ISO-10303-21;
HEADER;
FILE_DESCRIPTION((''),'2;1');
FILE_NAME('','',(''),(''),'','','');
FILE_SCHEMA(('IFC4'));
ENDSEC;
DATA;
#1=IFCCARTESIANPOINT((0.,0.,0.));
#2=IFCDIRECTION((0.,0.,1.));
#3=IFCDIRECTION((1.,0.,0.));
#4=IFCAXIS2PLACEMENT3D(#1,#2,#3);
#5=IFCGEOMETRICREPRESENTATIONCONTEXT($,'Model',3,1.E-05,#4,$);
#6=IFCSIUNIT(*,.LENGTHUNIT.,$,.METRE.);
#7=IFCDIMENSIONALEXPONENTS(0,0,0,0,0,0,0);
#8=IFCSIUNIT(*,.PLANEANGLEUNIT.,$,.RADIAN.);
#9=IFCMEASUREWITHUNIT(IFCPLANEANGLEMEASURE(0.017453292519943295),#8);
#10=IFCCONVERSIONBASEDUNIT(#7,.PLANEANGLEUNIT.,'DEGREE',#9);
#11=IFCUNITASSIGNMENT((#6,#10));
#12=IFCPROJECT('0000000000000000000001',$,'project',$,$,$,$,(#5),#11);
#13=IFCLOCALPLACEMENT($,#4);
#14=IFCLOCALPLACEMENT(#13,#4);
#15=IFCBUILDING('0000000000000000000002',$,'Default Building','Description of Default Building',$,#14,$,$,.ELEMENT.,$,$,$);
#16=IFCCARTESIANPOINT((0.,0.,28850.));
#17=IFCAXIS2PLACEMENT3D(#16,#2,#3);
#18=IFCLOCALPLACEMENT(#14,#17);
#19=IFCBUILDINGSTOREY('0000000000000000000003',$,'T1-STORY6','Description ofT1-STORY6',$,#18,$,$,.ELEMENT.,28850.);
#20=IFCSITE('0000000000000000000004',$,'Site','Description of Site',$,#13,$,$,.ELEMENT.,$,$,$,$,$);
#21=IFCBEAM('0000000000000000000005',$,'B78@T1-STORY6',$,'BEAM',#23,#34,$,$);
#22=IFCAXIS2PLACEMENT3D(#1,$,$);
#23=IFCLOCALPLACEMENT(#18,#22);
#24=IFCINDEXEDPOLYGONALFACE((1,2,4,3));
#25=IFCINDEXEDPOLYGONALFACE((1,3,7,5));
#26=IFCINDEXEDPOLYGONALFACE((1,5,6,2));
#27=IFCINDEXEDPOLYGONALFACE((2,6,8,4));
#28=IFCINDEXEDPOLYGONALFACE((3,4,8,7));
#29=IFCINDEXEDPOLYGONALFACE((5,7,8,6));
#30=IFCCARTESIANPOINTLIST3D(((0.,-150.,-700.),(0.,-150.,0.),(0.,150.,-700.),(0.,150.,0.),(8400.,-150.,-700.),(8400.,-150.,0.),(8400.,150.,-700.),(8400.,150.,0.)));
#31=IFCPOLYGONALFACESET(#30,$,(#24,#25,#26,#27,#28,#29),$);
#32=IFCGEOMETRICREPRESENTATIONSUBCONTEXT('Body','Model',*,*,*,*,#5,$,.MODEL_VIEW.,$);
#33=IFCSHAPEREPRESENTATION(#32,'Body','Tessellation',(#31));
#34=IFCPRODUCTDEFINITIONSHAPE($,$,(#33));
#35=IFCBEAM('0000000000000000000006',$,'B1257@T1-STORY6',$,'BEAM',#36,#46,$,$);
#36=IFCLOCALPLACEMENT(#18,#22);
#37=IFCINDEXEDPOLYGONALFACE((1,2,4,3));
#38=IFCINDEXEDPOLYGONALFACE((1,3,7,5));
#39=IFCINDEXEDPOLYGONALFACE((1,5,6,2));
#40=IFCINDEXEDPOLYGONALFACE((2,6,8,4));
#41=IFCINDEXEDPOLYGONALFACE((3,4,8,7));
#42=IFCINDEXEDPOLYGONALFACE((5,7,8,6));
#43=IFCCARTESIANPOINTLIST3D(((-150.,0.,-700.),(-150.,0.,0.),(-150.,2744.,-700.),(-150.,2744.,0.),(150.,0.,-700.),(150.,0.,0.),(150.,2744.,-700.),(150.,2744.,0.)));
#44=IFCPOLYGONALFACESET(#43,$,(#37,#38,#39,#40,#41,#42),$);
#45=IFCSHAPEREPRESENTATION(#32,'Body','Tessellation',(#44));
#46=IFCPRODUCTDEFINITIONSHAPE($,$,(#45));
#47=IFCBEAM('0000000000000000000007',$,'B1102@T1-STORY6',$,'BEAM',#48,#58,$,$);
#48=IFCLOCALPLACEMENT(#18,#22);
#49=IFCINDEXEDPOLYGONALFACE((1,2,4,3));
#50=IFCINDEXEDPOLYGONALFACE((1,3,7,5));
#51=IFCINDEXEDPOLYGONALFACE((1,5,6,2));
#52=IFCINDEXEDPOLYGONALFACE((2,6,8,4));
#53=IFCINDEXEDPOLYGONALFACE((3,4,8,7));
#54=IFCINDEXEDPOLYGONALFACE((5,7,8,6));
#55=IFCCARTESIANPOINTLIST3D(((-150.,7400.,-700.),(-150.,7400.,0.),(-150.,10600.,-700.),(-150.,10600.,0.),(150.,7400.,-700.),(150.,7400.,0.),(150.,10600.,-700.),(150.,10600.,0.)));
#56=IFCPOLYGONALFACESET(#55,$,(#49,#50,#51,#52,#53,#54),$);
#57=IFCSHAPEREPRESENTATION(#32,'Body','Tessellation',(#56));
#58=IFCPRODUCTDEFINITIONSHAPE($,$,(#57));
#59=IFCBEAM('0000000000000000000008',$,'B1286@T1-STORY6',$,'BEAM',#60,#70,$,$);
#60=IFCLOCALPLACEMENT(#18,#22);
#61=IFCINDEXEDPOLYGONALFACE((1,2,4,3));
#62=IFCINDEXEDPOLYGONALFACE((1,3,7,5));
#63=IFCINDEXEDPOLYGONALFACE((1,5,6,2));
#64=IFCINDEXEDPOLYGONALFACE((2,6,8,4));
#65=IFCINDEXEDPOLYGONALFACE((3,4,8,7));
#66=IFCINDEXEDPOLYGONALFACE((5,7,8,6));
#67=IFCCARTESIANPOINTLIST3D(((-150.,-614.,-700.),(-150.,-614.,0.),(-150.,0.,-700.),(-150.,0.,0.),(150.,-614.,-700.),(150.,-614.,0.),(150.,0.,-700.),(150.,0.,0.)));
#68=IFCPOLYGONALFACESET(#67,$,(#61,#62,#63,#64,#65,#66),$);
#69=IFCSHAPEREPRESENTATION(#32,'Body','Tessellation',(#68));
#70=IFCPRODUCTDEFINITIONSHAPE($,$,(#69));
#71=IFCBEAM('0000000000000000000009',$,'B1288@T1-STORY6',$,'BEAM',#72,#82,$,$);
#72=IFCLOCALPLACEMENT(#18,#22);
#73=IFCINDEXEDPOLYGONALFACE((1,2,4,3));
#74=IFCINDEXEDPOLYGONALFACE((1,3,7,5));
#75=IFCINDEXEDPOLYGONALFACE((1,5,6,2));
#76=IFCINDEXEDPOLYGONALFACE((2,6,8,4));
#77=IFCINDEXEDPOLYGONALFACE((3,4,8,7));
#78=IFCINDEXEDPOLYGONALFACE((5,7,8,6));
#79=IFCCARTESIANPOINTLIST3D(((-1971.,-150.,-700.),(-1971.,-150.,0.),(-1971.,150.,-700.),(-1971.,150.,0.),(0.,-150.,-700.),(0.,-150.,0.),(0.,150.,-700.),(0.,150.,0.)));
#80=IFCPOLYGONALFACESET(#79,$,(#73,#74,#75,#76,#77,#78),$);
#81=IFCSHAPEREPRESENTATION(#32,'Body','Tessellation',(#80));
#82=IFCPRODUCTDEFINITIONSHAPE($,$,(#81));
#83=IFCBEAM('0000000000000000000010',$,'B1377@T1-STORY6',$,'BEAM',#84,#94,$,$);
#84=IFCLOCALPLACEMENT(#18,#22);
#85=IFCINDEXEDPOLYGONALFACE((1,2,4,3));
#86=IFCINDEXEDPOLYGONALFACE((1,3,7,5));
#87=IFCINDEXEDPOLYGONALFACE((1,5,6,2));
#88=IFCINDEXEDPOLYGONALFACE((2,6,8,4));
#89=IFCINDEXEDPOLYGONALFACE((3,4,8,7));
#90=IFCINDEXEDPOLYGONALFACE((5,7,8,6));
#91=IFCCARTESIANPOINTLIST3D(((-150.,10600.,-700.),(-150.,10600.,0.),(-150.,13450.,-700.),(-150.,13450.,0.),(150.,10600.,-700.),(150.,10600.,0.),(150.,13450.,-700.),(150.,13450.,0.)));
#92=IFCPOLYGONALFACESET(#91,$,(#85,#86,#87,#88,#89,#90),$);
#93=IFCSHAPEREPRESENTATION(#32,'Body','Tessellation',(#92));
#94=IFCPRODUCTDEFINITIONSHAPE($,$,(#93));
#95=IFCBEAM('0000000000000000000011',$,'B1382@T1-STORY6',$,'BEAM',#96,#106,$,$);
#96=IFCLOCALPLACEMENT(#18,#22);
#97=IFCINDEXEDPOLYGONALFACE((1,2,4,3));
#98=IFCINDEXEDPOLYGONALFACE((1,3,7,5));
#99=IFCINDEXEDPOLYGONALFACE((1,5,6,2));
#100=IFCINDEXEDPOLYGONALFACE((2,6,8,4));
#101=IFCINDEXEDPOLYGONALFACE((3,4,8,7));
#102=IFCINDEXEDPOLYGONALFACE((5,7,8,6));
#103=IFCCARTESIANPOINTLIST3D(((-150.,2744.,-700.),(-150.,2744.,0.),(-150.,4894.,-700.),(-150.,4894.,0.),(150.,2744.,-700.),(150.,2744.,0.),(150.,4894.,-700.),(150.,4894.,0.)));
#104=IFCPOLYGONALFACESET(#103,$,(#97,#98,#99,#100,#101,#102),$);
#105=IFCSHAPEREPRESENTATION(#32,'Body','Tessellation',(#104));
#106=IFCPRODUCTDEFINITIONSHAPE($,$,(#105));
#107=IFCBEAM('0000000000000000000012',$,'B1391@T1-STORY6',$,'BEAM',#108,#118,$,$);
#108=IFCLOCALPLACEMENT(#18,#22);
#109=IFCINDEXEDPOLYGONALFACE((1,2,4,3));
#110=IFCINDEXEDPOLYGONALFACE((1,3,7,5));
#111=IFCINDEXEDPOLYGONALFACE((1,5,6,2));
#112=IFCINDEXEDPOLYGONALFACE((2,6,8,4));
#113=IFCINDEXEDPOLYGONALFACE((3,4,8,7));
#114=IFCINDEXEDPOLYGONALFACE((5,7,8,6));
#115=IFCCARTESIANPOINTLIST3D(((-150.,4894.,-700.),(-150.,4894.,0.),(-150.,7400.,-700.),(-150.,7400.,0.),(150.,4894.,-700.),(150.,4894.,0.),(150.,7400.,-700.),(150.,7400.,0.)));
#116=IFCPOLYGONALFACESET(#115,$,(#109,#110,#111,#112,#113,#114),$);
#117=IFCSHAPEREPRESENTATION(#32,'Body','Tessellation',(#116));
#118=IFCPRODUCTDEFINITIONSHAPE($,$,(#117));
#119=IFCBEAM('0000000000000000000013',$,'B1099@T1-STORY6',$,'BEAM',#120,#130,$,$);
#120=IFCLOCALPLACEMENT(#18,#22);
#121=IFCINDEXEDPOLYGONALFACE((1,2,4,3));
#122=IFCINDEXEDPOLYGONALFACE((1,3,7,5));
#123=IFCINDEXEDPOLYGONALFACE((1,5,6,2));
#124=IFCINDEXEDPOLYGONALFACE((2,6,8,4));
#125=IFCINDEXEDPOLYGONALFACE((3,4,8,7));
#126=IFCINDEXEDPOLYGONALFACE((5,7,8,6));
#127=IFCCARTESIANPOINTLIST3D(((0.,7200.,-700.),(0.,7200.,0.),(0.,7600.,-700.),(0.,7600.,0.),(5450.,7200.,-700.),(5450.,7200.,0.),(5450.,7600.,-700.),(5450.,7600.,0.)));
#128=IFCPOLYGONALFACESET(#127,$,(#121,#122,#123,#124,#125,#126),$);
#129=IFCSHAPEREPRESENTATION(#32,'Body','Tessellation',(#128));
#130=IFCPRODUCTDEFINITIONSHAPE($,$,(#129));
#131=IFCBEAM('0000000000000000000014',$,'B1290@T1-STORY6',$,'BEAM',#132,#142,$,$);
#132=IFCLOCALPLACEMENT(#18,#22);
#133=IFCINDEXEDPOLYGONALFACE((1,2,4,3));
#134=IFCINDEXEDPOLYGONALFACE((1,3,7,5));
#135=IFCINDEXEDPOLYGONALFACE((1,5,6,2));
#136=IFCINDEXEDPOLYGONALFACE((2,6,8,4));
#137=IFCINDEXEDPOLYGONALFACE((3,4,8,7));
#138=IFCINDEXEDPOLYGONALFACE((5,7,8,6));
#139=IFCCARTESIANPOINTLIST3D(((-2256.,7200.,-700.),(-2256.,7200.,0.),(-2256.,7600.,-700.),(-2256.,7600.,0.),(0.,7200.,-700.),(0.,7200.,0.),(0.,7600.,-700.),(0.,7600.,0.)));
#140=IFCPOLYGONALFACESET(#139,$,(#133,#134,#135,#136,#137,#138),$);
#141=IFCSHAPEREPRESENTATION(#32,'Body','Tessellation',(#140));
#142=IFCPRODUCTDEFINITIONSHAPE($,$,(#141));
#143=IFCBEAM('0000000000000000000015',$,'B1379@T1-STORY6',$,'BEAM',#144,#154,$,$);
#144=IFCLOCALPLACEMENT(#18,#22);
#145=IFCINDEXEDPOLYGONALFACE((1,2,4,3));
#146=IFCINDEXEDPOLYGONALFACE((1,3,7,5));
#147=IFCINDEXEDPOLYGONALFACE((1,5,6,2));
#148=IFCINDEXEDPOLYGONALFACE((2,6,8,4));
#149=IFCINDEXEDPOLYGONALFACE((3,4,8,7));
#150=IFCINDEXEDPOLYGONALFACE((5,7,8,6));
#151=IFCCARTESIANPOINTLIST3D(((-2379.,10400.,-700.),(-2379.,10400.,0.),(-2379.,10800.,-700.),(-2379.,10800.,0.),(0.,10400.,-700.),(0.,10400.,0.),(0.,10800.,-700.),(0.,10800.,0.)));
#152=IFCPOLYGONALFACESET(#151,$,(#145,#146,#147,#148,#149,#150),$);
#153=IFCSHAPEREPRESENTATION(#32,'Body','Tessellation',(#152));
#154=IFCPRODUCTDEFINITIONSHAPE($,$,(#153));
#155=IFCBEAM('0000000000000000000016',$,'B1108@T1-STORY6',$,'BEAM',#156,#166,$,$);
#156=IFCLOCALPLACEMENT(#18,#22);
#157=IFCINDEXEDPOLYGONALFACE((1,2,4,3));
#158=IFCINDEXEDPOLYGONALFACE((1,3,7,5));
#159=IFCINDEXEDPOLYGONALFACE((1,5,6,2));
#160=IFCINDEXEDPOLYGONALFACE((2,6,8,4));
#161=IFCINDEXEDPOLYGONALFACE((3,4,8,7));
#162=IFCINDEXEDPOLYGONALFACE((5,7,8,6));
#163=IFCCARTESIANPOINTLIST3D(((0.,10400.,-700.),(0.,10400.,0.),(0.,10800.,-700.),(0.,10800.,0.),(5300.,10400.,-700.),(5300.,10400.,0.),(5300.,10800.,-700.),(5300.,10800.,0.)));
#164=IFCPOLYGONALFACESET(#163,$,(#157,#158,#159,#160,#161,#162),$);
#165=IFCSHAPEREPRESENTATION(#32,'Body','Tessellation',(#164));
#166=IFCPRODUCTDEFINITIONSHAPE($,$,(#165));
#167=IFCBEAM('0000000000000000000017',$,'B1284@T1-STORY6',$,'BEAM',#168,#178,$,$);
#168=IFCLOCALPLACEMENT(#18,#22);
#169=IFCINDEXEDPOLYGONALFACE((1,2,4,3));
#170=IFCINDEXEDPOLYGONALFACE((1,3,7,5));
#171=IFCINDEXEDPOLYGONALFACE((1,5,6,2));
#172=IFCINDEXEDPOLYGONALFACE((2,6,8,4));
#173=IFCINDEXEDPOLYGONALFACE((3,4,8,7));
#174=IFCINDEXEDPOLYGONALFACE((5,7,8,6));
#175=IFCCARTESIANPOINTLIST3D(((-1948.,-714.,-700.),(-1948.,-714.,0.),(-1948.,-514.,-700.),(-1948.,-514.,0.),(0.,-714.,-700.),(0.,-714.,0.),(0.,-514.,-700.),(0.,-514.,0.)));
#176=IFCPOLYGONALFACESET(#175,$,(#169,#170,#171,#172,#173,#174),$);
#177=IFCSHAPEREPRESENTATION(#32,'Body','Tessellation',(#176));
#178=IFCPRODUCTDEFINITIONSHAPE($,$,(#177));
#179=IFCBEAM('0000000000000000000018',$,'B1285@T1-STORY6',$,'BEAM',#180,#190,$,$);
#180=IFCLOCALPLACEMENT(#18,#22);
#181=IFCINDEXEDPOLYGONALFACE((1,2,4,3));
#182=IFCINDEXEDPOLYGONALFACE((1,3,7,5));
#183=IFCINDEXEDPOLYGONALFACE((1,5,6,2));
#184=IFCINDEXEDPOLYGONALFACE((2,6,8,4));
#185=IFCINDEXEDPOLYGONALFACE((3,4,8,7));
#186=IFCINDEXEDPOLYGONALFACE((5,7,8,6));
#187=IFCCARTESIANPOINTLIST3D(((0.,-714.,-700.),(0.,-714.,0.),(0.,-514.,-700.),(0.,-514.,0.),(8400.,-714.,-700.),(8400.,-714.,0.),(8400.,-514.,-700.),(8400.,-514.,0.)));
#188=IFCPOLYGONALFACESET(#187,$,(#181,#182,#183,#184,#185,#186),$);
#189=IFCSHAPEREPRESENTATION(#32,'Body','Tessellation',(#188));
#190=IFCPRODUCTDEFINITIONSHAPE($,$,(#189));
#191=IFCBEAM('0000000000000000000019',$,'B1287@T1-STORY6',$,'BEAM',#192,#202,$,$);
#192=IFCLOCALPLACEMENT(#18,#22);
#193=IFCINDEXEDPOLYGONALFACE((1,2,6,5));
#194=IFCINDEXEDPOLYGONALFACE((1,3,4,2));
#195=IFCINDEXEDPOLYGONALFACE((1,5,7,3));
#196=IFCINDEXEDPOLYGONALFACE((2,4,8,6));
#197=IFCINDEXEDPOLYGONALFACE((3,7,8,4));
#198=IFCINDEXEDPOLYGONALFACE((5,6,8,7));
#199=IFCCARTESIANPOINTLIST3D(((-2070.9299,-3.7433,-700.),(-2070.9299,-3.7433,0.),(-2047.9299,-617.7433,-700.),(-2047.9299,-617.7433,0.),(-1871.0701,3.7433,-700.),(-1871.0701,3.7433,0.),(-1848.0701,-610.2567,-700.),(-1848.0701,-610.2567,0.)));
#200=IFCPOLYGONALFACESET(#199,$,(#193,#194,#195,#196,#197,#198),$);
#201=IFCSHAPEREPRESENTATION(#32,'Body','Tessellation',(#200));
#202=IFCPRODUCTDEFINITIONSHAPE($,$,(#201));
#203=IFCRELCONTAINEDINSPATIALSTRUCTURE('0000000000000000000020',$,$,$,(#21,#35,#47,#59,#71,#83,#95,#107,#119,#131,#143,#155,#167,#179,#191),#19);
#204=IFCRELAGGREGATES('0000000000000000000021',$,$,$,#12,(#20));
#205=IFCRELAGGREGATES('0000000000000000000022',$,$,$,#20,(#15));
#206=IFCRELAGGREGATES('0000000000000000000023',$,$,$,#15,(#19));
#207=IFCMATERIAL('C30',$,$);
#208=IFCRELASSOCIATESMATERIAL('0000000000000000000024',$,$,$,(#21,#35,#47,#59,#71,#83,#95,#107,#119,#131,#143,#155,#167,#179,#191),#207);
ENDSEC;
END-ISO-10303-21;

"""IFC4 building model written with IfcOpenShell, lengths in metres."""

from ifc_helpers import new_model, entity, si_unit, converted_unit, frame, origin_with_axes, place, context, subcontext, project, spatial, rectangle, extrude, material, element, save


model = new_model("IFC4")

# Units and contexts
model_context = context("Model", 3, precision=1e-05, world=origin_with_axes())
body_context = subcontext(model_context, "Body", "Model", "MODEL_VIEW")
ifc_project = project(units=[si_unit("LENGTHUNIT", "METRE"), converted_unit("PLANEANGLEUNIT", "DEGREE", entity("IfcPlaneAngleMeasure", 0.017453292519943295), si_unit("PLANEANGLEUNIT", "RADIAN"), dimensions=[0, 0, 0, 0, 0, 0, 0])], contexts=[model_context])

# Site, building, storey
site_placement = place(None, origin_with_axes())
site = spatial("IfcSite", under=ifc_project, at=site_placement, Name="Site", Description="Description of Site", CompositionType="ELEMENT")
building_placement = place(site_placement, origin_with_axes())
building = spatial("IfcBuilding", under=site, at=building_placement, Name="Default Building", Description="Description of Default Building", CompositionType="ELEMENT")
storey_placement = place(building_placement, frame((0.0, 0.0, 28850.0), z_axis=(0.0, 0.0, 1.0), x_axis=(1.0, 0.0, 0.0)))
storey = spatial("IfcBuildingStorey", under=building, at=storey_placement, Name="T1-STORY6", Description="Description ofT1-STORY6", CompositionType="ELEMENT", Elevation=28850.0)

# Beams
ifc_material_1 = material(Name="C30")
beam_1_placement = place(storey_placement, frame((0.0, 0.0, -350.0), z_axis=(1.0, 0.0, 0.0), x_axis=(0.0, 1.0, 0.0)))
element("IfcBeam", 1, at=beam_1_placement, inside=storey, material=ifc_material_1, Name="B78@T1-STORY6", ObjectType="BEAM", context=body_context, shape_type="SweptSolid", body=[
    extrude(rectangle(XDim=300.0, YDim=700.0), origin_with_axes(), (0.0, 0.0, 1.0), 8400.0),
])
beam_2_placement = place(storey_placement, frame((0.0, 0.0, -350.0), z_axis=(0.0, 1.0, 0.0), x_axis=(-1.0, 0.0, 0.0)))
element("IfcBeam", 2, at=beam_2_placement, inside=storey, material=ifc_material_1, Name="B1257@T1-STORY6", ObjectType="BEAM", context=body_context, shape_type="SweptSolid", body=[
    extrude(rectangle(XDim=300.0, YDim=700.0), origin_with_axes(), (0.0, 0.0, 1.0), 2744.0),
])
beam_3_placement = place(storey_placement, frame((0.0, 7400.0, -350.0), z_axis=(0.0, 1.0, 0.0), x_axis=(-1.0, 0.0, 0.0)))
element("IfcBeam", 3, at=beam_3_placement, inside=storey, material=ifc_material_1, Name="B1102@T1-STORY6", ObjectType="BEAM", context=body_context, shape_type="SweptSolid", body=[
    extrude(rectangle(XDim=300.0, YDim=700.0), origin_with_axes(), (0.0, 0.0, 1.0), 3200.0),
])
beam_4_placement = place(storey_placement, frame((0.0, -614.0, -350.0), z_axis=(0.0, 1.0, 0.0), x_axis=(-1.0, 0.0, 0.0)))
element("IfcBeam", 4, at=beam_4_placement, inside=storey, material=ifc_material_1, Name="B1286@T1-STORY6", ObjectType="BEAM", context=body_context, shape_type="SweptSolid", body=[
    extrude(rectangle(XDim=300.0, YDim=700.0), origin_with_axes(), (0.0, 0.0, 1.0), 614.0),
])
beam_5_placement = place(storey_placement, frame((-1971.0, 0.0, -350.0), z_axis=(1.0, 0.0, 0.0), x_axis=(0.0, 1.0, 0.0)))
element("IfcBeam", 5, at=beam_5_placement, inside=storey, material=ifc_material_1, Name="B1288@T1-STORY6", ObjectType="BEAM", context=body_context, shape_type="SweptSolid", body=[
    extrude(rectangle(XDim=300.0, YDim=700.0), origin_with_axes(), (0.0, 0.0, 1.0), 1971.0),
])
beam_6_placement = place(storey_placement, frame((0.0, 10600.0, -350.0), z_axis=(0.0, 1.0, 0.0), x_axis=(-1.0, 0.0, 0.0)))
element("IfcBeam", 6, at=beam_6_placement, inside=storey, material=ifc_material_1, Name="B1377@T1-STORY6", ObjectType="BEAM", context=body_context, shape_type="SweptSolid", body=[
    extrude(rectangle(XDim=300.0, YDim=700.0), origin_with_axes(), (0.0, 0.0, 1.0), 2850.0),
])
beam_7_placement = place(storey_placement, frame((0.0, 2744.0, -350.0), z_axis=(0.0, 1.0, 0.0), x_axis=(-1.0, 0.0, 0.0)))
element("IfcBeam", 7, at=beam_7_placement, inside=storey, material=ifc_material_1, Name="B1382@T1-STORY6", ObjectType="BEAM", context=body_context, shape_type="SweptSolid", body=[
    extrude(rectangle(XDim=300.0, YDim=700.0), origin_with_axes(), (0.0, 0.0, 1.0), 2150.0),
])
beam_8_placement = place(storey_placement, frame((0.0, 4894.0, -350.0), z_axis=(0.0, 1.0, 0.0), x_axis=(-1.0, 0.0, 0.0)))
element("IfcBeam", 8, at=beam_8_placement, inside=storey, material=ifc_material_1, Name="B1391@T1-STORY6", ObjectType="BEAM", context=body_context, shape_type="SweptSolid", body=[
    extrude(rectangle(XDim=300.0, YDim=700.0), origin_with_axes(), (0.0, 0.0, 1.0), 2506.0),
])
beam_9_placement = place(storey_placement, frame((0.0, 7400.0, -350.0), z_axis=(1.0, 0.0, 0.0), x_axis=(0.0, 1.0, 0.0)))
element("IfcBeam", 9, at=beam_9_placement, inside=storey, material=ifc_material_1, Name="B1099@T1-STORY6", ObjectType="BEAM", context=body_context, shape_type="SweptSolid", body=[
    extrude(rectangle(XDim=400.0, YDim=700.0), origin_with_axes(), (0.0, 0.0, 1.0), 5450.0),
])
beam_10_placement = place(storey_placement, frame((-2256.0, 7400.0, -350.0), z_axis=(1.0, 0.0, 0.0), x_axis=(0.0, 1.0, 0.0)))
element("IfcBeam", 10, at=beam_10_placement, inside=storey, material=ifc_material_1, Name="B1290@T1-STORY6", ObjectType="BEAM", context=body_context, shape_type="SweptSolid", body=[
    extrude(rectangle(XDim=400.0, YDim=700.0), origin_with_axes(), (0.0, 0.0, 1.0), 2256.0),
])
beam_11_placement = place(storey_placement, frame((-2379.0, 10600.0, -350.0), z_axis=(1.0, 0.0, 0.0), x_axis=(0.0, 1.0, 0.0)))
element("IfcBeam", 11, at=beam_11_placement, inside=storey, material=ifc_material_1, Name="B1379@T1-STORY6", ObjectType="BEAM", context=body_context, shape_type="SweptSolid", body=[
    extrude(rectangle(XDim=400.0, YDim=700.0), origin_with_axes(), (0.0, 0.0, 1.0), 2379.0),
])
beam_12_placement = place(storey_placement, frame((0.0, 10600.0, -350.0), z_axis=(1.0, 0.0, 0.0), x_axis=(0.0, 1.0, 0.0)))
element("IfcBeam", 12, at=beam_12_placement, inside=storey, material=ifc_material_1, Name="B1108@T1-STORY6", ObjectType="BEAM", context=body_context, shape_type="SweptSolid", body=[
    extrude(rectangle(XDim=400.0, YDim=700.0), origin_with_axes(), (0.0, 0.0, 1.0), 5300.0),
])
beam_13_placement = place(storey_placement, frame((-1948.0, -614.0, -350.0), z_axis=(1.0, 0.0, 0.0), x_axis=(0.0, 1.0, 0.0)))
element("IfcBeam", 13, at=beam_13_placement, inside=storey, material=ifc_material_1, Name="B1284@T1-STORY6", ObjectType="BEAM", context=body_context, shape_type="SweptSolid", body=[
    extrude(rectangle(XDim=200.0, YDim=700.0), origin_with_axes(), (0.0, 0.0, 1.0), 1948.0),
])
beam_14_placement = place(storey_placement, frame((0.0, -614.0, -350.0), z_axis=(1.0, 0.0, 0.0), x_axis=(0.0, 1.0, 0.0)))
element("IfcBeam", 14, at=beam_14_placement, inside=storey, material=ifc_material_1, Name="B1285@T1-STORY6", ObjectType="BEAM", context=body_context, shape_type="SweptSolid", body=[
    extrude(rectangle(XDim=200.0, YDim=700.0), origin_with_axes(), (0.0, 0.0, 1.0), 8400.0),
])
beam_15_placement = place(storey_placement, frame((-1971.0, 0.0, -350.0), z_axis=(0.037433, -0.999299, 0.0), x_axis=(0.999299, 0.037433, 0.0)))
element("IfcBeam", 15, at=beam_15_placement, inside=storey, material=ifc_material_1, Name="B1287@T1-STORY6", ObjectType="BEAM", context=body_context, shape_type="SweptSolid", body=[
    extrude(rectangle(XDim=200.0, YDim=700.0), origin_with_axes(), (0.0, 0.0, 1.0), 614.4306),
])

save(model, "model.ifc")
